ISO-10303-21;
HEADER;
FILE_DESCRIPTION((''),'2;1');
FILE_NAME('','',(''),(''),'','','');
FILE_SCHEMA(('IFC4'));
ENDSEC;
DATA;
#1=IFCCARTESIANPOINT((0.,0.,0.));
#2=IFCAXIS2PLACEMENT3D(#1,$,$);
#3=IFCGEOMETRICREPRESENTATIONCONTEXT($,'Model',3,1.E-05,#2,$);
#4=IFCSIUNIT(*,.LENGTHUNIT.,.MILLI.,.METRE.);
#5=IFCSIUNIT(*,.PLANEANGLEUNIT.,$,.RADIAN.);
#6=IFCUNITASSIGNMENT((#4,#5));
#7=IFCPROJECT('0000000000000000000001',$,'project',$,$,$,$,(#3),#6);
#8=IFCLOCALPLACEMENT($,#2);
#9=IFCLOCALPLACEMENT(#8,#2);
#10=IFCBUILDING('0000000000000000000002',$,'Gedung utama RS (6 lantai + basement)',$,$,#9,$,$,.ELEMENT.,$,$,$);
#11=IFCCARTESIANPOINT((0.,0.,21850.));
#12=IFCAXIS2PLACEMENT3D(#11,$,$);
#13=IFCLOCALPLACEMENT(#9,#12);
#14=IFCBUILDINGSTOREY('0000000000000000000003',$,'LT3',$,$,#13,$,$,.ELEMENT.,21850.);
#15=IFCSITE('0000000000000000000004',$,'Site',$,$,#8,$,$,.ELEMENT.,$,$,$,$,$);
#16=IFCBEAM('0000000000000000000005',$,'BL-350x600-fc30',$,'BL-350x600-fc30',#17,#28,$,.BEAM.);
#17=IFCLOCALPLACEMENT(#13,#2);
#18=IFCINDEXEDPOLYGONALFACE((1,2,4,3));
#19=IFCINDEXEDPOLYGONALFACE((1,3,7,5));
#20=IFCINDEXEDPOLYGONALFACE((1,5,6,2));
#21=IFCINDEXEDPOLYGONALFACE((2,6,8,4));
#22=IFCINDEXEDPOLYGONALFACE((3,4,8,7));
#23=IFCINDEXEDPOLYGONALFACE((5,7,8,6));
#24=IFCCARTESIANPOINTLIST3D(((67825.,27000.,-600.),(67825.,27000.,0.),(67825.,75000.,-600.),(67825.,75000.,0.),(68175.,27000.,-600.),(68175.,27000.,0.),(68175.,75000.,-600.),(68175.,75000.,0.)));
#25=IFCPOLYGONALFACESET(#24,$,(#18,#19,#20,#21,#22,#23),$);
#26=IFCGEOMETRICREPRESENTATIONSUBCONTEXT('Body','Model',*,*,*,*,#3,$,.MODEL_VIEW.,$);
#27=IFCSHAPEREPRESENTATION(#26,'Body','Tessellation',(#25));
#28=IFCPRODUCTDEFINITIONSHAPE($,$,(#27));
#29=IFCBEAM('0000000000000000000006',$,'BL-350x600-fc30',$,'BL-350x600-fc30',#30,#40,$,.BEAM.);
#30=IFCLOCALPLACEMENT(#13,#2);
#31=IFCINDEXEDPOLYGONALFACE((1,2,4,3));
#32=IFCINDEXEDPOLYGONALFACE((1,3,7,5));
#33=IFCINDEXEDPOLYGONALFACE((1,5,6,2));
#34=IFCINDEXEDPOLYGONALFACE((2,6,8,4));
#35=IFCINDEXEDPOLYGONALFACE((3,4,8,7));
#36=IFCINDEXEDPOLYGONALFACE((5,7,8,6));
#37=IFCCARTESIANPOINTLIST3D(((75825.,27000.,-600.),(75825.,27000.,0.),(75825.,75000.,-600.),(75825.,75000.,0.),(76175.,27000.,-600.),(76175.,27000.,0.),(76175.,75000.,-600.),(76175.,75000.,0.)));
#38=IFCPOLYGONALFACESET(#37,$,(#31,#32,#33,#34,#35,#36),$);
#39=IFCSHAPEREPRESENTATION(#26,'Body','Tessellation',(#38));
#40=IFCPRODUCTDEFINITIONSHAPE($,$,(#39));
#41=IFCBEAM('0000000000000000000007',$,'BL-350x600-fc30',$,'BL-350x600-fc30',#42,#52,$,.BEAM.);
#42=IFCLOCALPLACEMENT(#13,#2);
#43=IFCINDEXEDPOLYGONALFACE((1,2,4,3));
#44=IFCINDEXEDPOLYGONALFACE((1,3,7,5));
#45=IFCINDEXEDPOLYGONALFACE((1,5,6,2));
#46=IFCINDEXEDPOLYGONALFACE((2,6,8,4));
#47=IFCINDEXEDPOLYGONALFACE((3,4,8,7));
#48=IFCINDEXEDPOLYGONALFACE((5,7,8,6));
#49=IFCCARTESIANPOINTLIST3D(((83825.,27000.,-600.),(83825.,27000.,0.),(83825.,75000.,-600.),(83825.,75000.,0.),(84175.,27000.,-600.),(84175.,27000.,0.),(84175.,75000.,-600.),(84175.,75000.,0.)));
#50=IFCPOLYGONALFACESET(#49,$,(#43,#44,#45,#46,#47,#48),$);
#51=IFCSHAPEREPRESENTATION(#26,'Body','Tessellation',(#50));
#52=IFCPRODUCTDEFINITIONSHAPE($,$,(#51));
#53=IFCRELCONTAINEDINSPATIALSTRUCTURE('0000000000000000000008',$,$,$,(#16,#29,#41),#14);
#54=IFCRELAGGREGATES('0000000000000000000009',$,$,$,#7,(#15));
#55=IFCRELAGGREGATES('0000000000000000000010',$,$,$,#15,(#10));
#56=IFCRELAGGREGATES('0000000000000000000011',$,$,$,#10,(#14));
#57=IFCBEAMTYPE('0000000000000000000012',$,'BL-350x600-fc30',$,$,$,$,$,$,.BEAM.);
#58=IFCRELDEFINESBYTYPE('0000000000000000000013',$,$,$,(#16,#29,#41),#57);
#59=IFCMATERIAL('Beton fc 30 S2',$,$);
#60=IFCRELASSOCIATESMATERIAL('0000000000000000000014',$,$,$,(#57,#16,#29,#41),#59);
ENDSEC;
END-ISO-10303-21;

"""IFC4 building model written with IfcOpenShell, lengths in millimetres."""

from ifc_helpers import new_model, si_unit, frame, origin, origin_2d, place, context, subcontext, project, spatial, rectangle, extrude, material, material_profile, profile_set, profile_usage, type_object, element, save


model = new_model("IFC4")

# Units and contexts
model_context = context("Model", 3, precision=1e-05, world=origin())
body_context = subcontext(model_context, "Body", "Model", "MODEL_VIEW")
ifc_project = project(units=[si_unit("LENGTHUNIT", "METRE", prefix="MILLI"), si_unit("PLANEANGLEUNIT", "RADIAN")], contexts=[model_context])

# Site, building, storey
site_placement = place(None, origin())
site = spatial("IfcSite", under=ifc_project, at=site_placement, Name="Site", CompositionType="ELEMENT")
building_placement = place(site_placement, origin())
building = spatial("IfcBuilding", under=site, at=building_placement, Name="Gedung utama RS (6 lantai + basement)", CompositionType="ELEMENT")
storey_placement = place(building_placement, frame((0.0, 0.0, 21850.0)))
storey = spatial("IfcBuildingStorey", under=building, at=storey_placement, Name="LT3", CompositionType="ELEMENT", Elevation=21850.0)

# Beams
ifc_material = material(Name="Beton fc 30 S2")
ifc_material_profile_1 = material_profile(ifc_material, rectangle(XDim=350.0, YDim=600.0, at=origin_2d()), Name="BL-350x600-fc30")
ifc_profile_set_1 = profile_set([ifc_material_profile_1], Name="BL-350x600-fc30")
ifc_profile_usage_1 = profile_usage(ifc_profile_set_1, cardinal=8)
beam_type = type_object("IfcBeamType", Name="BL-350x600-fc30", PredefinedType="BEAM", material=ifc_profile_set_1)
for number, where, name in (
    (1, (68000.0, 27000.0, -300.0), "BL-350x600-fc30"),
    (2, (76000.0, 27000.0, -300.0), "BL-350x600-fc30"),
    (3, (84000.0, 27000.0, -300.0), "BL-350x600-fc30"),
):
    element("IfcBeam", number, at=place(storey_placement, frame(where)), inside=storey, type_object=beam_type, material=ifc_profile_usage_1, Name=name, ObjectType="BL-350x600-fc30", PredefinedType="BEAM", context=body_context, shape_type="SweptSolid", body=[
        extrude(rectangle(XDim=350.0, YDim=600.0, at=origin_2d()), frame((0.0, 0.0, 0.0), z_axis=(0.0, 1.0, 0.0), x_axis=(-1.0, 0.0, 0.0)), (0.0, 0.0, 1.0), 48000.0),
    ])

save(model, "model.ifc")
